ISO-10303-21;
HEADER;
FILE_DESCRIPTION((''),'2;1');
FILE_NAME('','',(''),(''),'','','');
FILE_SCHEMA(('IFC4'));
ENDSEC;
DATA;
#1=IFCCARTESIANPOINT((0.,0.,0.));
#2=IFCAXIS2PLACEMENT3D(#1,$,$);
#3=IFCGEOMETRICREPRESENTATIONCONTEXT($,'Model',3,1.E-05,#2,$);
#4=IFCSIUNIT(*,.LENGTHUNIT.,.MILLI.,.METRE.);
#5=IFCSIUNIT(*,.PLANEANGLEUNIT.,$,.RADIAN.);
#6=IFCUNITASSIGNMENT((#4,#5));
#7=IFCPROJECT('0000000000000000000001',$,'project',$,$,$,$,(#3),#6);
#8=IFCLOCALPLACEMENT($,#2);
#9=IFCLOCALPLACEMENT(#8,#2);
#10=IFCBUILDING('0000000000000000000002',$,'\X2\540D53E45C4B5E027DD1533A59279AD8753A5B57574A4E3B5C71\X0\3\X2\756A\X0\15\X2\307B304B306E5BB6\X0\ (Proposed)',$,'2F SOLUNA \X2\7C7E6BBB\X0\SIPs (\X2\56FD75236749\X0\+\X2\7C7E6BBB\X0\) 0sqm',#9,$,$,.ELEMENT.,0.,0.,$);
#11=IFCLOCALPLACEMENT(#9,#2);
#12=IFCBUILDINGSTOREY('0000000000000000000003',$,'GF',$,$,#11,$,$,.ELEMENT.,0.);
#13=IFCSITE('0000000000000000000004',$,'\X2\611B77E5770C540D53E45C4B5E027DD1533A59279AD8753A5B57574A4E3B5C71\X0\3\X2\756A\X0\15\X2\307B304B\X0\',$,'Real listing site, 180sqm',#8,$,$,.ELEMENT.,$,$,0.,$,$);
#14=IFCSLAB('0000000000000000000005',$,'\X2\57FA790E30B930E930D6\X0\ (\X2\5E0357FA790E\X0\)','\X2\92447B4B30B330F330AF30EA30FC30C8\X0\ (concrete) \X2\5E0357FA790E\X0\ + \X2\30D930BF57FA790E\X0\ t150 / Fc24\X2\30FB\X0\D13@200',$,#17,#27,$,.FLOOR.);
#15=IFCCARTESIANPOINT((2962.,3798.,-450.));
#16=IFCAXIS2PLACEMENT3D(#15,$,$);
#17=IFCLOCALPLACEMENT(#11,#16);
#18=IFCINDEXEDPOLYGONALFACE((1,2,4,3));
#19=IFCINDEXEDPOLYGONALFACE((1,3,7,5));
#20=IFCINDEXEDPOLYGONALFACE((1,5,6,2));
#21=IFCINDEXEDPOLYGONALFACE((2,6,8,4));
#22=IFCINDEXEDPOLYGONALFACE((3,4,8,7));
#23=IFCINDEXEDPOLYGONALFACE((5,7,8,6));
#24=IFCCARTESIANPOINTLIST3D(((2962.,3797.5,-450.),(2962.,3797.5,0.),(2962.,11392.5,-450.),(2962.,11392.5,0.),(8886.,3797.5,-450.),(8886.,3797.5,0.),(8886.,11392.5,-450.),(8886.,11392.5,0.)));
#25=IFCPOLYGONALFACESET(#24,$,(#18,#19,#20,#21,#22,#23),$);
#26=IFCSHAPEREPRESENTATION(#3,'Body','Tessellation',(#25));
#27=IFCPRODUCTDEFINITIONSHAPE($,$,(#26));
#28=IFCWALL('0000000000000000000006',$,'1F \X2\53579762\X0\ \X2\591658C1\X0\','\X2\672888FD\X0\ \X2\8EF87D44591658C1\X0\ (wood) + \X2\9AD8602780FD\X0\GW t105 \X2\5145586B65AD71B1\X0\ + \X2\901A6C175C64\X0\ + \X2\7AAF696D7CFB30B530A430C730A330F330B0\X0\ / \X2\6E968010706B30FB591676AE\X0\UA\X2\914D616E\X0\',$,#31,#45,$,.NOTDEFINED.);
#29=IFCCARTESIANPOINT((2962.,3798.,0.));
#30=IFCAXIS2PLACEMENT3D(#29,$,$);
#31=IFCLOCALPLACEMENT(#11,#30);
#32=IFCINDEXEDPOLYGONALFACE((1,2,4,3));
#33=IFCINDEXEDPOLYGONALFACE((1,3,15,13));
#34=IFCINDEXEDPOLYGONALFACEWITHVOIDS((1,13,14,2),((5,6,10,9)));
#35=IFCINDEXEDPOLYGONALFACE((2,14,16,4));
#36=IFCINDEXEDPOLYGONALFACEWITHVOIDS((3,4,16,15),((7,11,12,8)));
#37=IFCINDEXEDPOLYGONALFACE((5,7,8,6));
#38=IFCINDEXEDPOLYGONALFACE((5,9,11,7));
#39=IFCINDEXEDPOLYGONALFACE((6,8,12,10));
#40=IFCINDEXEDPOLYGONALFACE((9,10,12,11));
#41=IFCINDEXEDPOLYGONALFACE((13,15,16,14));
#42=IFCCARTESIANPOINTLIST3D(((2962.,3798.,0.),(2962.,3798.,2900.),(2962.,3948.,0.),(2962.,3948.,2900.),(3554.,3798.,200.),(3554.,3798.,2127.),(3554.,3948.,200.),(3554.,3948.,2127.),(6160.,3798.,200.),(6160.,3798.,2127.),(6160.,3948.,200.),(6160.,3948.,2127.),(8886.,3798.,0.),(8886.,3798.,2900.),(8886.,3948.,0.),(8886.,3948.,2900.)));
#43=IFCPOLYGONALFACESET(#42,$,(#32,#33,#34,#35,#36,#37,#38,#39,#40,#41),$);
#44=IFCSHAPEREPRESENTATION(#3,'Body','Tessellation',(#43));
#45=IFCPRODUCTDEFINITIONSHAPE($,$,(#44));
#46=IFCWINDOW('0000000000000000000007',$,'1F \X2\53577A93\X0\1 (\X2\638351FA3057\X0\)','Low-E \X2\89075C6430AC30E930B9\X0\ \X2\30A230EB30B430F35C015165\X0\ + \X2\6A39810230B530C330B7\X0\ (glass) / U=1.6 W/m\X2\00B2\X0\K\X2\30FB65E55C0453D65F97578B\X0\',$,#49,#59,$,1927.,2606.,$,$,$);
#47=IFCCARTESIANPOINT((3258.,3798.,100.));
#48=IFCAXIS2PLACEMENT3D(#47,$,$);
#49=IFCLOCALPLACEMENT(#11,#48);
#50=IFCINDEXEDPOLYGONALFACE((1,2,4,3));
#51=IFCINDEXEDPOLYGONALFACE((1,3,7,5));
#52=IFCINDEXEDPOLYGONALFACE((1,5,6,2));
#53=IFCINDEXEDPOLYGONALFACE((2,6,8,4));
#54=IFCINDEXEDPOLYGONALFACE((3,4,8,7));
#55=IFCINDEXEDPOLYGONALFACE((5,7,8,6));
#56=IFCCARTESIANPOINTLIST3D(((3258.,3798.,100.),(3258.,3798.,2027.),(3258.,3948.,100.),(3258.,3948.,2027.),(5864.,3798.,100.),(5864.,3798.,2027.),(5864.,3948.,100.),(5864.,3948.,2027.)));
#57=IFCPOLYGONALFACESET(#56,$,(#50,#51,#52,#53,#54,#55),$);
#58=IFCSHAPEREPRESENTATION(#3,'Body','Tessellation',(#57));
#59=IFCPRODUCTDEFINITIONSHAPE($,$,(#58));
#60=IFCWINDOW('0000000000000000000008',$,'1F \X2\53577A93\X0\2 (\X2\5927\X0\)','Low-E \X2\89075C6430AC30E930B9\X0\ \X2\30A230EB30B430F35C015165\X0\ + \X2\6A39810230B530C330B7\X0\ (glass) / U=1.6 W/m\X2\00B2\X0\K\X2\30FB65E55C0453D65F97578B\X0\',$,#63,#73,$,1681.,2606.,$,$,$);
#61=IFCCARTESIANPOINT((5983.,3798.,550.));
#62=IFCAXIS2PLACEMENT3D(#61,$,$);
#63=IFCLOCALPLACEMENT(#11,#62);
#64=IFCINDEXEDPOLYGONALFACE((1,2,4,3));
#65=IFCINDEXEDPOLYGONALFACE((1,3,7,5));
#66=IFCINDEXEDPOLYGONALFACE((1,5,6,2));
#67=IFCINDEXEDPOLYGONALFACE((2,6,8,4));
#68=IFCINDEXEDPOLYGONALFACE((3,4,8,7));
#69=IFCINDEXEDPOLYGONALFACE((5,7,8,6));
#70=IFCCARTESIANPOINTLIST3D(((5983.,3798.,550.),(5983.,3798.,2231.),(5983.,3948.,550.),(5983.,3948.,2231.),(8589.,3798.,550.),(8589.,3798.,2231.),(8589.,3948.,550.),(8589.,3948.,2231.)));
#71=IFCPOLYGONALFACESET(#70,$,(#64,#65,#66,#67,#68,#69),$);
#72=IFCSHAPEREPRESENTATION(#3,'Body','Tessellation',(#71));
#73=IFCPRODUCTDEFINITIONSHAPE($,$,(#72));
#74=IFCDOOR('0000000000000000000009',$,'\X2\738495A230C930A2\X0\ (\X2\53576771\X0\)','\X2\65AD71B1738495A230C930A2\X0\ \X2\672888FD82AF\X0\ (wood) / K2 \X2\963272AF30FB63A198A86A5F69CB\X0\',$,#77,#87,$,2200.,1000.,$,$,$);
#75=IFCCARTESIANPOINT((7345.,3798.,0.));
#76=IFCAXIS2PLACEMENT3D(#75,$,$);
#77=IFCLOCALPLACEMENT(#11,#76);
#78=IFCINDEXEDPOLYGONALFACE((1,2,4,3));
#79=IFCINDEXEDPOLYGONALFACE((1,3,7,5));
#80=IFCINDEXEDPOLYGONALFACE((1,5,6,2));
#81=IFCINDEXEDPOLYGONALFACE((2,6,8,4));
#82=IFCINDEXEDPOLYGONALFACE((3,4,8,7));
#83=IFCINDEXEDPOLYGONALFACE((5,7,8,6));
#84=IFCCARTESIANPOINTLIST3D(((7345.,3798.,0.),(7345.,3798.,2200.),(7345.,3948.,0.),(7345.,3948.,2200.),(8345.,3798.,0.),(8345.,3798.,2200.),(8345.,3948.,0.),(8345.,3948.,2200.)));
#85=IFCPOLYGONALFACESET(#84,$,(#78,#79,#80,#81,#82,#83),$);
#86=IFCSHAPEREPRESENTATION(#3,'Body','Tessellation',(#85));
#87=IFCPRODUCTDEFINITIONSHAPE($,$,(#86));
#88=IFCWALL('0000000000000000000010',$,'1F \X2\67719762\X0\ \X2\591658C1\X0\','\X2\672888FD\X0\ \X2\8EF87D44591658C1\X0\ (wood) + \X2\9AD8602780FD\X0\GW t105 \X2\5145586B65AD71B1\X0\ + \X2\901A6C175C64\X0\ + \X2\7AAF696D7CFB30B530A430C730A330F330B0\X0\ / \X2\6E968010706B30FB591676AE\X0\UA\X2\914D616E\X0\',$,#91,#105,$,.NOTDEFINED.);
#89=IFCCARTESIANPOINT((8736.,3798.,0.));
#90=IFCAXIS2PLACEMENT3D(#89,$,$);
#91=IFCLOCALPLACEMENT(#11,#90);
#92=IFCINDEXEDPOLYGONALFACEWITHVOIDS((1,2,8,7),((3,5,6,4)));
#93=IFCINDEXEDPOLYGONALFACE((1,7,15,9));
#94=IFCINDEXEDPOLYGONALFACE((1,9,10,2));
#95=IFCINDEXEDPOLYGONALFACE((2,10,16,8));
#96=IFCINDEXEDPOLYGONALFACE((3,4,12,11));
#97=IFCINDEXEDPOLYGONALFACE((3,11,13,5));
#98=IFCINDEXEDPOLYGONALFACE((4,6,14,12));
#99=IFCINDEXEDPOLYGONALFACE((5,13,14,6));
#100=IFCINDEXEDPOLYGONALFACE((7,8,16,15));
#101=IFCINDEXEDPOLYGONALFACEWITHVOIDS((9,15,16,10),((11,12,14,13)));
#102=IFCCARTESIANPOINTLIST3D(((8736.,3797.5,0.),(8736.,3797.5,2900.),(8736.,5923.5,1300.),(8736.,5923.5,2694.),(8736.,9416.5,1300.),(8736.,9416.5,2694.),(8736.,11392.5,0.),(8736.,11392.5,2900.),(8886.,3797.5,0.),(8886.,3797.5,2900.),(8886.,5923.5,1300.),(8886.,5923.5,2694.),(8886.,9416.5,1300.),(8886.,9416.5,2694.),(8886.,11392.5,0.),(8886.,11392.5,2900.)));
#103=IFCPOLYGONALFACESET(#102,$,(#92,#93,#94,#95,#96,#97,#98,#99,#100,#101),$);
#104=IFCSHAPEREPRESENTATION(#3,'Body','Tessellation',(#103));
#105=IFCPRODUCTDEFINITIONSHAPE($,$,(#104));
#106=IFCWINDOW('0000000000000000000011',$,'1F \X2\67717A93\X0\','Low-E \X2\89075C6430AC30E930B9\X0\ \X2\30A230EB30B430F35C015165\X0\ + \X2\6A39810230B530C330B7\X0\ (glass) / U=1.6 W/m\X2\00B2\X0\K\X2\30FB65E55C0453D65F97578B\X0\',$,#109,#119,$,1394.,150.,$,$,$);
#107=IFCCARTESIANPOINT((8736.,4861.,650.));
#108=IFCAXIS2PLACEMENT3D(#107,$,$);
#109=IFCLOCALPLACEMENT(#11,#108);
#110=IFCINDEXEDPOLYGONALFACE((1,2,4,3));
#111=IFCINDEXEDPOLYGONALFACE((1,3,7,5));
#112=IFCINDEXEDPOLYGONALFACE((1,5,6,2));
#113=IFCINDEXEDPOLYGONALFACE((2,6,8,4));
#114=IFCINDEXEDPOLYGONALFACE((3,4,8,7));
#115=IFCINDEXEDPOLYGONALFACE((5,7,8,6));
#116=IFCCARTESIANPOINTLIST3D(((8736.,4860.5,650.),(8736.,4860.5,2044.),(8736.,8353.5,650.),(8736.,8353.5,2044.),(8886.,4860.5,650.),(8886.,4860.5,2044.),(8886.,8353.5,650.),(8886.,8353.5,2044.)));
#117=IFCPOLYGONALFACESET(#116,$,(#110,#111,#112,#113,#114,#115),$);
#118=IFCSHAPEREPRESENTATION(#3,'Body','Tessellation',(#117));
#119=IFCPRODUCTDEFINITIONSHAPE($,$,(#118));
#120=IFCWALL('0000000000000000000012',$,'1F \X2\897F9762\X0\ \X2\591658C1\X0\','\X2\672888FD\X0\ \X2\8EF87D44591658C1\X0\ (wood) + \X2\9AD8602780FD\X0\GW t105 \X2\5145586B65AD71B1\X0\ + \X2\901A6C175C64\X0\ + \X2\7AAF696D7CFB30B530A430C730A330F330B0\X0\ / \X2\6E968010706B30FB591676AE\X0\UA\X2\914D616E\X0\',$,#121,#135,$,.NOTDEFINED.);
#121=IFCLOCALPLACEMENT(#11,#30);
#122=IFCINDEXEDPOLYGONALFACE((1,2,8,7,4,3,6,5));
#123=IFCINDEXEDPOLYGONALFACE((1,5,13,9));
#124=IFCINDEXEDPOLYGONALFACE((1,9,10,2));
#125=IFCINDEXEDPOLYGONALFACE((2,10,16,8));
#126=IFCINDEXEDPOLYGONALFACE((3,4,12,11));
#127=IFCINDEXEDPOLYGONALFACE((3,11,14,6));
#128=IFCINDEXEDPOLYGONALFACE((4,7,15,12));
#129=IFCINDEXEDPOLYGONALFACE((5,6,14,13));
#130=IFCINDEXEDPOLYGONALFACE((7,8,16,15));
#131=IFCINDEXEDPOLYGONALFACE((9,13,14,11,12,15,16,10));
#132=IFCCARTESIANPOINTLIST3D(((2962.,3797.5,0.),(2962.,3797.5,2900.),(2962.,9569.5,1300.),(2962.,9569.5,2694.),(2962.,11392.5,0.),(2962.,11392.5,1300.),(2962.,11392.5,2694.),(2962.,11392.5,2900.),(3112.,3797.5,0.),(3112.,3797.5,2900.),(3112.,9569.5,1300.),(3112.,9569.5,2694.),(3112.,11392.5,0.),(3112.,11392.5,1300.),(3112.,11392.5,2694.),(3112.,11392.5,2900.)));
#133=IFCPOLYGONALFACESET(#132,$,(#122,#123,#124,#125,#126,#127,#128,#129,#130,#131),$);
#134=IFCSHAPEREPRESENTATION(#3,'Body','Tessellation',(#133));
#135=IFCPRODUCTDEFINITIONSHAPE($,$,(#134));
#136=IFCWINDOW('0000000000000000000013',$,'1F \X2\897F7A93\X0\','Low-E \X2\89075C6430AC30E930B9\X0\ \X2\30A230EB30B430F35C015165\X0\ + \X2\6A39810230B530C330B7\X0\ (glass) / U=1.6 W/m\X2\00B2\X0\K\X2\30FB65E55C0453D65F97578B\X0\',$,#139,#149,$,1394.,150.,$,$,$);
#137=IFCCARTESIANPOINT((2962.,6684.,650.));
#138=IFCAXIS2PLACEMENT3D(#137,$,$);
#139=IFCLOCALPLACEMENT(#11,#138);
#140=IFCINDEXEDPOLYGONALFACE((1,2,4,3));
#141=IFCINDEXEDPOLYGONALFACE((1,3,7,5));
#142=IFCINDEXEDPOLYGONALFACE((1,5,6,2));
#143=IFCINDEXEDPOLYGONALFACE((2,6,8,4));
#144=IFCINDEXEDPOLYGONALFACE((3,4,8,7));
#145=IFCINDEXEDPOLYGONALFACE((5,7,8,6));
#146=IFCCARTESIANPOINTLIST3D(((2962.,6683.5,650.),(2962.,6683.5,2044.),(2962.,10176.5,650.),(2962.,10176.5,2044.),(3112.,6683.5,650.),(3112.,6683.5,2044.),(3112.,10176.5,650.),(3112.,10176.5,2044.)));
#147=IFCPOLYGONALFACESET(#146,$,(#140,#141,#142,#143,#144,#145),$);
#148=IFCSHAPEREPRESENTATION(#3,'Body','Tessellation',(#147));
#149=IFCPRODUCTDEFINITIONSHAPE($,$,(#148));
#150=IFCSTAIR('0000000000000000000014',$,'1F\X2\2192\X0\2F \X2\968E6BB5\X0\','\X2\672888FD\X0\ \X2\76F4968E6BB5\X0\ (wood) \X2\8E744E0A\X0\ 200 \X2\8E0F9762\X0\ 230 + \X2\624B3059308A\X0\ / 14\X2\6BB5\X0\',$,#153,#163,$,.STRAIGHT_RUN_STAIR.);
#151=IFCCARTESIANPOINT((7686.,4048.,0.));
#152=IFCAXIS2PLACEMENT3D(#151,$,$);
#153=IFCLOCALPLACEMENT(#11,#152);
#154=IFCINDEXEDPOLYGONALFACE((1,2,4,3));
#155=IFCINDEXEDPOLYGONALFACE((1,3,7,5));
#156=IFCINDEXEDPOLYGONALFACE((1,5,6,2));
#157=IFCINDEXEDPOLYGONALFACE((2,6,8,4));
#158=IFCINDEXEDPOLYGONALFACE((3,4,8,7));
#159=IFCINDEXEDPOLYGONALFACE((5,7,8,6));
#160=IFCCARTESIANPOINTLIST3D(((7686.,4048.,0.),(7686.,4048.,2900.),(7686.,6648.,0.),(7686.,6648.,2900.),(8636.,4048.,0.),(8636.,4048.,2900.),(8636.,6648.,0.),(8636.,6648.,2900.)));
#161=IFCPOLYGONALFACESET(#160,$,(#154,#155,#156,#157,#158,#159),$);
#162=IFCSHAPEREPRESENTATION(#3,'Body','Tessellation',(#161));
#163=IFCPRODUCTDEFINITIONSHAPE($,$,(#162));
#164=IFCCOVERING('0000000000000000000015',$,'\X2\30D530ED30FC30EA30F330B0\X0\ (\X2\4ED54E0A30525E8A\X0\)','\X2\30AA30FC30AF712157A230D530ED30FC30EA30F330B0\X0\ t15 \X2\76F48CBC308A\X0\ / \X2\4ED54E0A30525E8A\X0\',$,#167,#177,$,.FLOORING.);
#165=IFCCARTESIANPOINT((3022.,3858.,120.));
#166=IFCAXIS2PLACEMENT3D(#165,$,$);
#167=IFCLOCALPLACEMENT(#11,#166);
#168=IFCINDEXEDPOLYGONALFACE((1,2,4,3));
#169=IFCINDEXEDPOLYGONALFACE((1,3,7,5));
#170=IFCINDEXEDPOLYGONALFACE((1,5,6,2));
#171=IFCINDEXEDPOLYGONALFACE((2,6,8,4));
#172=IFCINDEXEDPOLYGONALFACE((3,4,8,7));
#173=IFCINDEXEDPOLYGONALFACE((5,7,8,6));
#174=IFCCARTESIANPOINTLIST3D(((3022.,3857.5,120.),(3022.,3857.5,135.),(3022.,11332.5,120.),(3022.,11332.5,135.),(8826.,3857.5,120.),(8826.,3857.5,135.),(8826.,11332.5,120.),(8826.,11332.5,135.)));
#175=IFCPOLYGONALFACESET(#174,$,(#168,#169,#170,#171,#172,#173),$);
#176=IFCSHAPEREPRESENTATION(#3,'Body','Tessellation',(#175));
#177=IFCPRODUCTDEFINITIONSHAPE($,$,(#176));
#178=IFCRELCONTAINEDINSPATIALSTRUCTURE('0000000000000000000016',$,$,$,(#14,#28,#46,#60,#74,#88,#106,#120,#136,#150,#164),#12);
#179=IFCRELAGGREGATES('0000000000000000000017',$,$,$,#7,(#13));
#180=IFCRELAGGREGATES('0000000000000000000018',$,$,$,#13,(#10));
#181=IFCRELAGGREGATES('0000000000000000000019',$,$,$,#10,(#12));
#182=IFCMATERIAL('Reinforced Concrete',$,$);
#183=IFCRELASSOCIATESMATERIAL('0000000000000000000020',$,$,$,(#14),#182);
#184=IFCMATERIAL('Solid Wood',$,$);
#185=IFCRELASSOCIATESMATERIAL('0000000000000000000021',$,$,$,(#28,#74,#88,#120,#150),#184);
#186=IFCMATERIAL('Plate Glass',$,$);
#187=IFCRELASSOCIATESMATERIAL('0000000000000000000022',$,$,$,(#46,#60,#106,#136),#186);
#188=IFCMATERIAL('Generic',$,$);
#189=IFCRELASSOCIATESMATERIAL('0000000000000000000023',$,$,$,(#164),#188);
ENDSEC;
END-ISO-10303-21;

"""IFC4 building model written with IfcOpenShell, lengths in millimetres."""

from ifc_helpers import new_model, si_unit, frame, frame_2d, origin, place, context, project, spatial, rectangle, extrude, material, element, fill, save


model = new_model("IFC4")

# Units and contexts
model_context = context("Model", 3, precision=1e-05, world=origin())
ifc_project = project(units=[si_unit("LENGTHUNIT", "METRE", prefix="MILLI"), si_unit("PLANEANGLEUNIT", "RADIAN")], contexts=[model_context])

# Site, building, storey
site_placement = place(None, origin())
site = spatial("IfcSite", under=ifc_project, at=site_placement, Name="愛知県名古屋市緑区大高町字坊主山3番15ほか", ObjectType="Real listing site, 180sqm", CompositionType="ELEMENT", RefElevation=0.0)
building_placement = place(site_placement, origin())
building = spatial("IfcBuilding", under=site, at=building_placement, Name="名古屋市緑区大高町字坊主山3番15ほかの家 (Proposed)", ObjectType="2F SOLUNA 籾殻SIPs (国産杉+籾殻) 0sqm", CompositionType="ELEMENT", ElevationOfRefHeight=0.0, ElevationOfTerrain=0.0)
storey_placement = place(building_placement, origin())
storey = spatial("IfcBuildingStorey", under=building, at=storey_placement, Name="GF", CompositionType="ELEMENT", Elevation=0.0)

# Slab
ifc_material_1 = material(Name="Reinforced Concrete")
slab_1_placement = place(storey_placement, frame((2962.0, 3798.0, -450.0)))
element("IfcSlab", 1, at=slab_1_placement, inside=storey, material=ifc_material_1, Name="基礎スラブ (布基礎)", Description="鉄筋コンクリート (concrete) 布基礎 + ベタ基礎 t150 / Fc24・D13@200", PredefinedType="FLOOR", context=model_context, shape_type="SweptSolid", body=[
    extrude(rectangle(XDim=5924.0, YDim=7595.0, at=frame_2d((2962.0, 3797.0))), frame((2962.0, 3798.0, -450.0)), (0.0, 0.0, 1.0), 450.0),
])
ifc_material_2 = material(Name="Solid Wood")

# Wall, openings, windows, door
wall_1_placement = place(storey_placement, frame((2962.0, 3798.0, 0.0)))
wall_1 = element("IfcWall", 2, at=wall_1_placement, inside=storey, material=ifc_material_2, Name="1F 南面 外壁", Description="木製 軸組外壁 (wood) + 高性能GW t105 充填断熱 + 通気層 + 窯業系サイディング / 準耐火・外皮UA配慮", PredefinedType="NOTDEFINED", context=model_context, shape_type="SweptSolid", body=[
    extrude(rectangle(XDim=5924.0, YDim=150.0, at=frame_2d((2962.0, 75.0))), frame((2962.0, 3798.0, 0.0)), (0.0, 0.0, 1.0), 2900.0),
])
opening_1_placement = place(storey_placement, frame((3258.0, 3798.0, 100.0)))
opening_1 = element("IfcOpeningElement", 3, at=opening_1_placement, cuts=wall_1, PredefinedType="NOTDEFINED", context=model_context, shape_type="SweptSolid", body=[
    extrude(rectangle(XDim=2606.0, YDim=150.0, at=frame_2d((1303.0, 75.0))), frame((3258.0, 3798.0, 100.0)), (0.0, 0.0, 1.0), 1927.0),
])
opening_2_placement = place(storey_placement, frame((5983.0, 3798.0, 550.0)))
opening_2 = element("IfcOpeningElement", 4, at=opening_2_placement, cuts=wall_1, PredefinedType="NOTDEFINED", context=model_context, shape_type="SweptSolid", body=[
    extrude(rectangle(XDim=2606.0, YDim=150.0, at=frame_2d((1303.0, 75.0))), frame((5983.0, 3798.0, 550.0)), (0.0, 0.0, 1.0), 1681.0),
])
opening_3_placement = place(storey_placement, frame((7345.0, 3798.0, 0.0)))
opening_3 = element("IfcOpeningElement", 5, at=opening_3_placement, cuts=wall_1, PredefinedType="NOTDEFINED", context=model_context, shape_type="SweptSolid", body=[
    extrude(rectangle(XDim=1000.0, YDim=150.0, at=frame_2d((500.0, 75.0))), frame((7345.0, 3798.0, 0.0)), (0.0, 0.0, 1.0), 2200.0),
])
ifc_material_3 = material(Name="Plate Glass")
window_1_placement = place(storey_placement, frame((3258.0, 3798.0, 100.0)))
window_1 = element("IfcWindow", 6, at=window_1_placement, inside=storey, material=ifc_material_3, Name="1F 南窓1 (掃出し)", Description="Low-E 複層ガラス アルゴン封入 + 樹脂サッシ (glass) / U=1.6 W/m²K・日射取得型", OverallHeight=1927.0, OverallWidth=2606.0, context=model_context, shape_type="SweptSolid", body=[
    extrude(rectangle(XDim=2606.0, YDim=150.0, at=frame_2d((1303.0, 75.0))), frame((3258.0, 3798.0, 100.0)), (0.0, 0.0, 1.0), 1927.0),
])
fill(opening_1, window_1)
window_2_placement = place(storey_placement, frame((5983.0, 3798.0, 550.0)))
window_2 = element("IfcWindow", 7, at=window_2_placement, inside=storey, material=ifc_material_3, Name="1F 南窓2 (大)", Description="Low-E 複層ガラス アルゴン封入 + 樹脂サッシ (glass) / U=1.6 W/m²K・日射取得型", OverallHeight=1681.0, OverallWidth=2606.0, context=model_context, shape_type="SweptSolid", body=[
    extrude(rectangle(XDim=2606.0, YDim=150.0, at=frame_2d((1303.0, 75.0))), frame((5983.0, 3798.0, 550.0)), (0.0, 0.0, 1.0), 1681.0),
])
fill(opening_2, window_2)
door_placement = place(storey_placement, frame((7345.0, 3798.0, 0.0)))
door = element("IfcDoor", 8, at=door_placement, inside=storey, material=ifc_material_2, Name="玄関ドア (南東)", Description="断熱玄関ドア 木製芯 (wood) / K2 防犯・採風機構", OverallHeight=2200.0, OverallWidth=1000.0, context=model_context, shape_type="SweptSolid", body=[
    extrude(rectangle(XDim=1000.0, YDim=150.0, at=frame_2d((500.0, 75.0))), frame((7345.0, 3798.0, 0.0)), (0.0, 0.0, 1.0), 2200.0),
])
fill(opening_3, door)

# Walls, openings, windows
wall_2_placement = place(storey_placement, frame((8736.0, 3798.0, 0.0)))
wall_2 = element("IfcWall", 9, at=wall_2_placement, inside=storey, material=ifc_material_2, Name="1F 東面 外壁", Description="木製 軸組外壁 (wood) + 高性能GW t105 充填断熱 + 通気層 + 窯業系サイディング / 準耐火・外皮UA配慮", PredefinedType="NOTDEFINED", context=model_context, shape_type="SweptSolid", body=[
    extrude(rectangle(XDim=150.0, YDim=7595.0, at=frame_2d((75.0, 3797.0))), frame((8736.0, 3798.0, 0.0)), (0.0, 0.0, 1.0), 2900.0),
])
opening_4_placement = place(storey_placement, frame((8736.0, 4861.0, 650.0)))
opening_4 = element("IfcOpeningElement", 10, at=opening_4_placement, cuts=wall_2, PredefinedType="NOTDEFINED", context=model_context, shape_type="SweptSolid", body=[
    extrude(rectangle(XDim=150.0, YDim=3493.0, at=frame_2d((75.0, 1746.0))), frame((8736.0, 4861.0, 650.0)), (0.0, 0.0, 1.0), 1394.0),
])
window_3_placement = place(storey_placement, frame((8736.0, 4861.0, 650.0)))
window_3 = element("IfcWindow", 11, at=window_3_placement, inside=storey, material=ifc_material_3, Name="1F 東窓", Description="Low-E 複層ガラス アルゴン封入 + 樹脂サッシ (glass) / U=1.6 W/m²K・日射取得型", OverallHeight=1394.0, OverallWidth=150.0, context=model_context, shape_type="SweptSolid", body=[
    extrude(rectangle(XDim=150.0, YDim=3493.0, at=frame_2d((75.0, 1746.0))), frame((8736.0, 4861.0, 650.0)), (0.0, 0.0, 1.0), 1394.0),
])
fill(opening_4, window_3)
wall_3_placement = place(storey_placement, frame((2962.0, 3798.0, 0.0)))
wall_3 = element("IfcWall", 12, at=wall_3_placement, inside=storey, material=ifc_material_2, Name="1F 西面 外壁", Description="木製 軸組外壁 (wood) + 高性能GW t105 充填断熱 + 通気層 + 窯業系サイディング / 準耐火・外皮UA配慮", PredefinedType="NOTDEFINED", context=model_context, shape_type="SweptSolid", body=[
    extrude(rectangle(XDim=150.0, YDim=7595.0, at=frame_2d((75.0, 3797.0))), frame((2962.0, 3798.0, 0.0)), (0.0, 0.0, 1.0), 2900.0),
])
opening_5_placement = place(storey_placement, frame((2962.0, 6684.0, 650.0)))
opening_5 = element("IfcOpeningElement", 13, at=opening_5_placement, cuts=wall_3, PredefinedType="NOTDEFINED", context=model_context, shape_type="SweptSolid", body=[
    extrude(rectangle(XDim=150.0, YDim=3493.0, at=frame_2d((75.0, 1746.0))), frame((2962.0, 6684.0, 650.0)), (0.0, 0.0, 1.0), 1394.0),
])
window_4_placement = place(storey_placement, frame((2962.0, 6684.0, 650.0)))
window_4 = element("IfcWindow", 14, at=window_4_placement, inside=storey, material=ifc_material_3, Name="1F 西窓", Description="Low-E 複層ガラス アルゴン封入 + 樹脂サッシ (glass) / U=1.6 W/m²K・日射取得型", OverallHeight=1394.0, OverallWidth=150.0, context=model_context, shape_type="SweptSolid", body=[
    extrude(rectangle(XDim=150.0, YDim=3493.0, at=frame_2d((75.0, 1746.0))), frame((2962.0, 6684.0, 650.0)), (0.0, 0.0, 1.0), 1394.0),
])
fill(opening_5, window_4)

# Stair
stair_placement = place(storey_placement, frame((7686.0, 4048.0, 0.0)))
element("IfcStair", 15, at=stair_placement, inside=storey, material=ifc_material_2, Name="1F→2F 階段", Description="木製 直階段 (wood) 蹴上 200 踏面 230 + 手すり / 14段", PredefinedType="STRAIGHT_RUN_STAIR", context=model_context, shape_type="SweptSolid", body=[
    extrude(rectangle(XDim=950.0, YDim=2600.0, at=frame_2d((475.0, 1300.0))), frame((7686.0, 4048.0, 0.0)), (0.0, 0.0, 1.0), 2900.0),
])

# Covering
ifc_material_4 = material(Name="Generic")
covering_placement = place(storey_placement, frame((3022.0, 3858.0, 120.0)))
element("IfcCovering", 16, at=covering_placement, inside=storey, material=ifc_material_4, Name="フローリング (仕上げ床)", Description="オーク無垢フローリング t15 直貼り / 仕上げ床", PredefinedType="FLOORING", context=model_context, shape_type="SweptSolid", body=[
    extrude(rectangle(XDim=5804.0, YDim=7475.0, at=frame_2d((2902.0, 3737.0))), frame((3022.0, 3858.0, 120.0)), (0.0, 0.0, 1.0), 15.0),
])

save(model, "model.ifc")
